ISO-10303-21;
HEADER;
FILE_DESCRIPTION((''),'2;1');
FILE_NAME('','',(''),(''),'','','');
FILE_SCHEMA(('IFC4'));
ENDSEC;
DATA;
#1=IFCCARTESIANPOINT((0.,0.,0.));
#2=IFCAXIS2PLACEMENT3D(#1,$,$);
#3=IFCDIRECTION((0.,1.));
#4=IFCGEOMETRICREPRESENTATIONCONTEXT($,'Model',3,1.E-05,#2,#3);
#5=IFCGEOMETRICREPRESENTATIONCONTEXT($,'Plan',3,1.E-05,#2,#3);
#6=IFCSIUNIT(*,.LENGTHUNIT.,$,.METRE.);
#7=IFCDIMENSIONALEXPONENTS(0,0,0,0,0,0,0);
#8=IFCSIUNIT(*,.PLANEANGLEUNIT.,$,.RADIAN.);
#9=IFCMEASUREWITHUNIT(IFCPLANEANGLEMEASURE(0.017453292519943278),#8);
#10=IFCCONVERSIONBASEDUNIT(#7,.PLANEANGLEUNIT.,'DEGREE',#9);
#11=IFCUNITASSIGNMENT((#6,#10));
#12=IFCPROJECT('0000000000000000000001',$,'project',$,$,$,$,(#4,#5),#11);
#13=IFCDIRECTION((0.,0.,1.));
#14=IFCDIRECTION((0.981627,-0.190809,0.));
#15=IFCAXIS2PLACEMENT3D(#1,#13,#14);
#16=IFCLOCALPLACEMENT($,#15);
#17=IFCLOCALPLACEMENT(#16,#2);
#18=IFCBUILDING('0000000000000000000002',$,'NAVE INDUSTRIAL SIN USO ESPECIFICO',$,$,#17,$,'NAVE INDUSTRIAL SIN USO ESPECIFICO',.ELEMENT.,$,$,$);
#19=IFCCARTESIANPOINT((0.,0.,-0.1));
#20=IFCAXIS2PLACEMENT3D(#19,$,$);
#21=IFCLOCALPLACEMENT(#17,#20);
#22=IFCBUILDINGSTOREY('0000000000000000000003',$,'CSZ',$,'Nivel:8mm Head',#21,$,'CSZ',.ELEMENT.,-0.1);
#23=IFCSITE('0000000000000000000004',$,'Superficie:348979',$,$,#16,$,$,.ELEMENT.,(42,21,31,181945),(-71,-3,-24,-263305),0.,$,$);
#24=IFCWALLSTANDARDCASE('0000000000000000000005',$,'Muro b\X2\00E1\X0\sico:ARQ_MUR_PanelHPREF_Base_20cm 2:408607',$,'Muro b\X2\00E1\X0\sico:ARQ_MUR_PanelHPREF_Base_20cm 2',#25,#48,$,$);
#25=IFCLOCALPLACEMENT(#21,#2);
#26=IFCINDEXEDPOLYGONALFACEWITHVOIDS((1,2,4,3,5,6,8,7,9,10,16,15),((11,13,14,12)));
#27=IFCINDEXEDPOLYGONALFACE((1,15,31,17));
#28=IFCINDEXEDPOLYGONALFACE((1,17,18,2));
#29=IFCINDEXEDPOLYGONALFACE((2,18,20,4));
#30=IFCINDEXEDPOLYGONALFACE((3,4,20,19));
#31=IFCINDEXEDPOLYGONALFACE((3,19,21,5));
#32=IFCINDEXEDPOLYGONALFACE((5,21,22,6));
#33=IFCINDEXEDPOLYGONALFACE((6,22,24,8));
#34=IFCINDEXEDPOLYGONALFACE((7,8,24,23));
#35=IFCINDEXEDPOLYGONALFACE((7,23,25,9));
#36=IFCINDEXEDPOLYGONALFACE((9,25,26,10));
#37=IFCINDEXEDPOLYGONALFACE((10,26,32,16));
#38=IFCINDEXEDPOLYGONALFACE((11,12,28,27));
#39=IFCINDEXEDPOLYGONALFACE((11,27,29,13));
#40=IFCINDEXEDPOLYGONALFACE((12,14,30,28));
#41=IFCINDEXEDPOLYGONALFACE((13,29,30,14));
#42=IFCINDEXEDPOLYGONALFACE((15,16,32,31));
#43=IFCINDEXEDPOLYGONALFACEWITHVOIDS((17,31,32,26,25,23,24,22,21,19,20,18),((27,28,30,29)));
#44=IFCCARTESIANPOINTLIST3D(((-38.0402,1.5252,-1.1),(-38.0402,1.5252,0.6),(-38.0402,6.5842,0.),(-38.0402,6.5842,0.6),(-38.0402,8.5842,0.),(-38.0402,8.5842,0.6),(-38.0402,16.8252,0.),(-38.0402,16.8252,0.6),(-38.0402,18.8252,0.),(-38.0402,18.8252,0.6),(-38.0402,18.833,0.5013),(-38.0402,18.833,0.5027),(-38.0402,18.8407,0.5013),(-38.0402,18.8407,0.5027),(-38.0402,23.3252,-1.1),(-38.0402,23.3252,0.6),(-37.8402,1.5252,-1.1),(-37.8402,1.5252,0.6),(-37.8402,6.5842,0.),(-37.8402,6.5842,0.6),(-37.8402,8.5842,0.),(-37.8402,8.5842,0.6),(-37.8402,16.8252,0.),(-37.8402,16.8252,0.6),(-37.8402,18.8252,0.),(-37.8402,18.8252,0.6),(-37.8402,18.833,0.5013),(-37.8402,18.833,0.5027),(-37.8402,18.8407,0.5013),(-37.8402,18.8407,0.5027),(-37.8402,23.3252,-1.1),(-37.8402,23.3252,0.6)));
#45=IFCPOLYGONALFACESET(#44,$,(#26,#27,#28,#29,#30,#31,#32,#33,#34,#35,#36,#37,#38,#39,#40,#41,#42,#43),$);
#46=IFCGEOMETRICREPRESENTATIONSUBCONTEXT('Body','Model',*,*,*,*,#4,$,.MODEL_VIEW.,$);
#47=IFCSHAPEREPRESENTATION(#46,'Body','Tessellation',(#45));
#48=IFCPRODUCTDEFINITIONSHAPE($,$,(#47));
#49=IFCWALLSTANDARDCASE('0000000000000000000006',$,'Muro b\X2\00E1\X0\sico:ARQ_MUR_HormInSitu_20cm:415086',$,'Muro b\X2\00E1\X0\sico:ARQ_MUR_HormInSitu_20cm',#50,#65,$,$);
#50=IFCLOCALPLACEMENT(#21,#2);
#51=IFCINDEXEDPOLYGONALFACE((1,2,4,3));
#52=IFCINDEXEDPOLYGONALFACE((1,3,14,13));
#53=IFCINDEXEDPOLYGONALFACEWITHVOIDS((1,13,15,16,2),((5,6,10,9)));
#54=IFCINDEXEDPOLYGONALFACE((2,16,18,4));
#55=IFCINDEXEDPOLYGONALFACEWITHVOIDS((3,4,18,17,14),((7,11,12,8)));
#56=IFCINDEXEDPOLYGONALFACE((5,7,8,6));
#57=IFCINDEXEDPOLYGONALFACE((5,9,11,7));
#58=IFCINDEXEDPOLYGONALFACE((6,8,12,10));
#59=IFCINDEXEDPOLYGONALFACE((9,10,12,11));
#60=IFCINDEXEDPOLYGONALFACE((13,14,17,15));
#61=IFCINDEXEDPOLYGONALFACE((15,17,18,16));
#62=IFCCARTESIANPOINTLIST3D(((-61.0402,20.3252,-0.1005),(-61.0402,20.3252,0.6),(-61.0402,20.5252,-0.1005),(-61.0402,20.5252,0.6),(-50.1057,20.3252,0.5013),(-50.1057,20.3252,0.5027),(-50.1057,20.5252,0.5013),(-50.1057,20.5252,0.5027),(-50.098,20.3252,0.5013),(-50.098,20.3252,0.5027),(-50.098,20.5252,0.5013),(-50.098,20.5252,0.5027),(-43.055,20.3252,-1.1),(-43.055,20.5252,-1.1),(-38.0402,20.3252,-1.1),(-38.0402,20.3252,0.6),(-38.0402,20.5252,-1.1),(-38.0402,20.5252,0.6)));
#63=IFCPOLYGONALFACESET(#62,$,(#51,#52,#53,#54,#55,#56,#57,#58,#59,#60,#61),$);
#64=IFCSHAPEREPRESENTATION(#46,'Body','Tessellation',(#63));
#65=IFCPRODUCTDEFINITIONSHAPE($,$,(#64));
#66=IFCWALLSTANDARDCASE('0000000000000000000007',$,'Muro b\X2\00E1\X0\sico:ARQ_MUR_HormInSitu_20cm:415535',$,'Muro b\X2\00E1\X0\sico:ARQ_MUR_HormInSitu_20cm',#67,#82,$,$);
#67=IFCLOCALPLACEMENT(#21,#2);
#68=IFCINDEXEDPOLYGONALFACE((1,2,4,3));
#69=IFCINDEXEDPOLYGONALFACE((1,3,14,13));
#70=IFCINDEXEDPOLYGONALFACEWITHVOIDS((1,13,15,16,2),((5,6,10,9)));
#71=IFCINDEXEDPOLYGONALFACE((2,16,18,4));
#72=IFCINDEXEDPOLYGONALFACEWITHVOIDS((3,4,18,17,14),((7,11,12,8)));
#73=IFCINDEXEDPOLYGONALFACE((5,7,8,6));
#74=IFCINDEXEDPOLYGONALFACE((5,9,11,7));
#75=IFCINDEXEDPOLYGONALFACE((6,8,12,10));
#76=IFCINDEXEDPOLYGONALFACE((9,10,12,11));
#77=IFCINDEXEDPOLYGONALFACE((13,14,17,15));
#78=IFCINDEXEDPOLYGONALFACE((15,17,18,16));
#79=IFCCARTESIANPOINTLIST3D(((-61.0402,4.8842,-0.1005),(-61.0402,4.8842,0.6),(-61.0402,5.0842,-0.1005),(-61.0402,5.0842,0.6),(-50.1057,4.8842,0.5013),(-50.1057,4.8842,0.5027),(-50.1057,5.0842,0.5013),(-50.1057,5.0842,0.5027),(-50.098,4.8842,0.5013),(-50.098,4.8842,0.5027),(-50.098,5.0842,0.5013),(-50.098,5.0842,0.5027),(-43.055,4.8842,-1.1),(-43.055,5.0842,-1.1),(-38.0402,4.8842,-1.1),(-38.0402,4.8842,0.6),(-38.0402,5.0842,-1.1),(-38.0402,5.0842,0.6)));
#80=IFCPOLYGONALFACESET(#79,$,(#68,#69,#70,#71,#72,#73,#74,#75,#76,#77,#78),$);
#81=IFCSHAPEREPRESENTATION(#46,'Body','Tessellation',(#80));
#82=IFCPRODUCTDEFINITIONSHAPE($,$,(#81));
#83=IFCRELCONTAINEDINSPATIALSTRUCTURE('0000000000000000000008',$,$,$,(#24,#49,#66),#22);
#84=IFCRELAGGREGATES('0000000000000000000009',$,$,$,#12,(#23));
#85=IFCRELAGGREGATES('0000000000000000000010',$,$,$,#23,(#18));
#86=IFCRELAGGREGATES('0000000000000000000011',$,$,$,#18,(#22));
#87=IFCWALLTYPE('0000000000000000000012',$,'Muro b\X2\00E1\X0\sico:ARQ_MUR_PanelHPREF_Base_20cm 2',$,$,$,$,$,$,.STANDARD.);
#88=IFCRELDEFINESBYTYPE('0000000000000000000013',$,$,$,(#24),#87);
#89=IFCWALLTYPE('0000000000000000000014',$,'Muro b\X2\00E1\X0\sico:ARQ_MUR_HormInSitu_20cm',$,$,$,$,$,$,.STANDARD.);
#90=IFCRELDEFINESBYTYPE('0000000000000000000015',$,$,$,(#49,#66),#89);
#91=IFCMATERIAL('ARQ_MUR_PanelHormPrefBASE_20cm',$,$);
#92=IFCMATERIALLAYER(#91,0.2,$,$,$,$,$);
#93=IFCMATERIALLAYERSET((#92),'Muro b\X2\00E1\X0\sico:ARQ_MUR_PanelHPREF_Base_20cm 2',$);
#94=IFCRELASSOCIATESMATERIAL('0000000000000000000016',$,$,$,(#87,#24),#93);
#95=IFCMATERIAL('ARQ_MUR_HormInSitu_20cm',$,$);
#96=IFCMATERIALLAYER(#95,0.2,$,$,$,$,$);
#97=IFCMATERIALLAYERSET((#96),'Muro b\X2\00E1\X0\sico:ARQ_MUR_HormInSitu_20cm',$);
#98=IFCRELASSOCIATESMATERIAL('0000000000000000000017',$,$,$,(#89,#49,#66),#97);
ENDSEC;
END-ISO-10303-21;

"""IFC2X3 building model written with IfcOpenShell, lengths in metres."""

from ifc_helpers import new_model, entity, si_unit, converted_unit, direction, frame, frame_2d, origin, origin_2d_with_axis, place, context, subcontext, project, spatial, rectangle, extrude, clip, halfspace, material, layer, layer_set, layer_usage, type_object, element, save


model = new_model("IFC2X3")

# Units and contexts
model_context = context("Model", 3, precision=1e-05, world=origin(), true_north=direction((0.0, 1.0)))
plan_context = context("Plan", 3, precision=1e-05, world=origin(), true_north=direction((0.0, 1.0)))
body_context = subcontext(model_context, "Body", "Model", "MODEL_VIEW")
ifc_project = project(units=[si_unit("LENGTHUNIT", "METRE"), converted_unit("PLANEANGLEUNIT", "DEGREE", entity("IfcPlaneAngleMeasure", 0.017453292519943278), si_unit("PLANEANGLEUNIT", "RADIAN"), dimensions=[0, 0, 0, 0, 0, 0, 0])], contexts=[model_context, plan_context])

# Site, building, storey
site_placement = place(None, frame((0.0, 0.0, 0.0), z_axis=(0.0, 0.0, 1.0), x_axis=(0.981627, -0.190809, 0.0)))
site = spatial("IfcSite", under=ifc_project, at=site_placement, Name="Superficie:348979", CompositionType="ELEMENT", RefLatitude=(42, 21, 31, 181945), RefLongitude=(-71, -3, -24, -263305), RefElevation=0.0)
building_placement = place(site_placement, origin())
building = spatial("IfcBuilding", under=site, at=building_placement, Name="NAVE INDUSTRIAL SIN USO ESPECIFICO", LongName="NAVE INDUSTRIAL SIN USO ESPECIFICO", CompositionType="ELEMENT")
storey_placement = place(building_placement, frame((0.0, 0.0, -0.1)))
storey = spatial("IfcBuildingStorey", under=building, at=storey_placement, Name="CSZ", ObjectType="Nivel:8mm Head", LongName="CSZ", CompositionType="ELEMENT", Elevation=-0.1)

# Wall, openings
ifc_material_1 = material(Name="ARQ_MUR_PanelHormPrefBASE_20cm")
ifc_layer_1 = layer(ifc_material_1, 0.2)
ifc_layer_set_1 = layer_set([ifc_layer_1], Name="Muro básico:ARQ_MUR_PanelHPREF_Base_20cm 2")
ifc_layer_usage_1 = layer_usage(ifc_layer_set_1, "AXIS2", "NEGATIVE", 0.1)
wall_type_1 = type_object("IfcWallType", Name="Muro básico:ARQ_MUR_PanelHPREF_Base_20cm 2", PredefinedType="STANDARD", material=ifc_layer_set_1)
wall_1_placement = place(storey_placement, frame((-37.9402, 1.5252, -1.1), z_axis=(0.0, 0.0, 1.0), x_axis=(0.0, 1.0, 0.0)))
wall_1 = element("IfcWallStandardCase", 1, at=wall_1_placement, inside=storey, type_object=wall_type_1, material=ifc_layer_usage_1, Name="Muro básico:ARQ_MUR_PanelHPREF_Base_20cm 2:408607", ObjectType="Muro básico:ARQ_MUR_PanelHPREF_Base_20cm 2", context=body_context, shape_type="SweptSolid", body=[
    extrude(rectangle(XDim=21.8, YDim=0.2, at=frame_2d((10.9, 0.0), x_axis=(-1.0, 0.0))), origin(), (0.0, 0.0, 1.0), 1.7),
])
opening_1_placement = place(wall_1_placement, frame((17.3078, 0.1, 1.6013)))
element("IfcOpeningElement", 2, at=opening_1_placement, cuts=wall_1, ObjectType="Opening", context=body_context, shape_type="SweptSolid", body=[
    extrude(rectangle(XDim=0.0014, YDim=0.0077, at=origin_2d_with_axis()), frame((0.0039, -0.2, 0.0007), z_axis=(0.0, 1.0, 0.0), x_axis=(0.0, 0.0, -1.0)), (0.0, 0.0, 1.0), 0.2),
])
opening_2_placement = place(wall_1_placement, frame((15.3, 0.1, 1.1)))
element("IfcOpeningElement", 3, at=opening_2_placement, cuts=wall_1, ObjectType="Opening", context=body_context, shape_type="SweptSolid", body=[
    extrude(rectangle(XDim=0.6, YDim=2.0, at=frame_2d((0.0, 0.0), x_axis=(1.0, 0.0))), frame((1.0, -0.2, 0.3), z_axis=(0.0, 1.0, 0.0), x_axis=(0.0, 0.0, -1.0)), (0.0, 0.0, 1.0), 0.2),
])
opening_3_placement = place(wall_1_placement, frame((5.059, 0.1, 1.1)))
element("IfcOpeningElement", 4, at=opening_3_placement, cuts=wall_1, ObjectType="Opening", context=body_context, shape_type="SweptSolid", body=[
    extrude(rectangle(XDim=0.6, YDim=2.0, at=origin_2d_with_axis()), frame((1.0, -0.2, 0.3), z_axis=(0.0, 1.0, 0.0), x_axis=(0.0, 0.0, -1.0)), (0.0, 0.0, 1.0), 0.2),
])
opening_4_placement = place(wall_1_placement, frame((-1.5252, -37.9402, 1.7)))
element("IfcOpeningElement", 5, at=opening_4_placement, cuts=wall_1, ObjectType="Opening", context=body_context, shape_type="SweptSolid", body=[
    extrude(rectangle(XDim=3.0, YDim=3.0, at=frame_2d((0.0, 0.0), x_axis=(0.0, 1.0))), frame((17.8252, 36.3162, 1.5), z_axis=(0.0, 1.0, 0.0), x_axis=(-1.0, 0.0, 0.0)), (0.0, 0.0, 1.0), 3.048),
])
opening_5_placement = place(wall_1_placement, frame((-1.5252, -37.9402, 1.7)))
element("IfcOpeningElement", 6, at=opening_5_placement, cuts=wall_1, ObjectType="Opening", context=body_context, shape_type="SweptSolid", body=[
    extrude(rectangle(XDim=3.0, YDim=3.0, at=frame_2d((0.0, 0.0), x_axis=(0.0, 1.0))), frame((7.5842, 36.3162, 1.5), z_axis=(0.0, 1.0, 0.0), x_axis=(-1.0, 0.0, 0.0)), (0.0, 0.0, 1.0), 3.048),
])

# Walls, openings
ifc_material_2 = material(Name="ARQ_MUR_HormInSitu_20cm")
ifc_layer_2 = layer(ifc_material_2, 0.2)
ifc_layer_set_2 = layer_set([ifc_layer_2], Name="Muro básico:ARQ_MUR_HormInSitu_20cm")
ifc_layer_usage_2 = layer_usage(ifc_layer_set_2, "AXIS2", "NEGATIVE", 0.1)
wall_type_2 = type_object("IfcWallType", Name="Muro básico:ARQ_MUR_HormInSitu_20cm", PredefinedType="STANDARD", material=ifc_layer_set_2)
wall_2_placement = place(storey_placement, frame((-38.0402, 20.4252, -1.1), z_axis=(0.0, 0.0, 1.0), x_axis=(-1.0, 0.0, 0.0)))
wall_2 = element("IfcWallStandardCase", 7, at=wall_2_placement, inside=storey, type_object=wall_type_2, material=ifc_layer_usage_2, Name="Muro básico:ARQ_MUR_HormInSitu_20cm:415086", ObjectType="Muro básico:ARQ_MUR_HormInSitu_20cm", context=body_context, shape_type="Clipping", body=[
    clip(extrude(rectangle(XDim=23.0, YDim=0.2, at=frame_2d((11.5, 0.0), x_axis=(-1.0, 0.0))), origin(), (0.0, 0.0, 1.0), 1.7), halfspace(frame((23.0, -0.1, 0.9995), z_axis=(0.05549, 0.0, -0.998459), x_axis=(0.0, 1.0, 0.0)), False)),
])
opening_6_placement = place(wall_2_placement, frame((12.0655, 0.1, 1.6013)))
element("IfcOpeningElement", 8, at=opening_6_placement, cuts=wall_2, ObjectType="Opening", context=body_context, shape_type="SweptSolid", body=[
    extrude(rectangle(XDim=0.0014, YDim=0.0077, at=frame_2d((0.0, 0.0), x_axis=(1.0, 0.0))), frame((-0.0039, -0.2, 0.0007), z_axis=(0.0, 1.0, 0.0), x_axis=(0.0, 0.0, -1.0)), (0.0, 0.0, 1.0), 0.2),
])
ifc_layer_usage_3 = layer_usage(ifc_layer_set_2, "AXIS2", "NEGATIVE", 0.1)
wall_3_placement = place(storey_placement, frame((-38.0402, 4.9842, -1.1), z_axis=(0.0, 0.0, 1.0), x_axis=(-1.0, 0.0, 0.0)))
wall_3 = element("IfcWallStandardCase", 9, at=wall_3_placement, inside=storey, type_object=wall_type_2, material=ifc_layer_usage_3, Name="Muro básico:ARQ_MUR_HormInSitu_20cm:415535", ObjectType="Muro básico:ARQ_MUR_HormInSitu_20cm", context=body_context, shape_type="Clipping", body=[
    clip(extrude(rectangle(XDim=23.0, YDim=0.2, at=frame_2d((11.5, 0.0), x_axis=(-1.0, 0.0))), origin(), (0.0, 0.0, 1.0), 1.7), halfspace(frame((23.0, -0.1, 0.9995), z_axis=(0.05549, 0.0, -0.998459), x_axis=(0.0, 1.0, 0.0)), False)),
])
opening_7_placement = place(wall_3_placement, frame((12.0655, 0.1, 1.6013)))
element("IfcOpeningElement", 10, at=opening_7_placement, cuts=wall_3, ObjectType="Opening", context=body_context, shape_type="SweptSolid", body=[
    extrude(rectangle(XDim=0.0014, YDim=0.0077, at=frame_2d((0.0, 0.0), x_axis=(1.0, 0.0))), frame((-0.0039, -0.2, 0.0007), z_axis=(0.0, 1.0, 0.0), x_axis=(0.0, 0.0, -1.0)), (0.0, 0.0, 1.0), 0.2),
])

save(model, "model.ifc")
